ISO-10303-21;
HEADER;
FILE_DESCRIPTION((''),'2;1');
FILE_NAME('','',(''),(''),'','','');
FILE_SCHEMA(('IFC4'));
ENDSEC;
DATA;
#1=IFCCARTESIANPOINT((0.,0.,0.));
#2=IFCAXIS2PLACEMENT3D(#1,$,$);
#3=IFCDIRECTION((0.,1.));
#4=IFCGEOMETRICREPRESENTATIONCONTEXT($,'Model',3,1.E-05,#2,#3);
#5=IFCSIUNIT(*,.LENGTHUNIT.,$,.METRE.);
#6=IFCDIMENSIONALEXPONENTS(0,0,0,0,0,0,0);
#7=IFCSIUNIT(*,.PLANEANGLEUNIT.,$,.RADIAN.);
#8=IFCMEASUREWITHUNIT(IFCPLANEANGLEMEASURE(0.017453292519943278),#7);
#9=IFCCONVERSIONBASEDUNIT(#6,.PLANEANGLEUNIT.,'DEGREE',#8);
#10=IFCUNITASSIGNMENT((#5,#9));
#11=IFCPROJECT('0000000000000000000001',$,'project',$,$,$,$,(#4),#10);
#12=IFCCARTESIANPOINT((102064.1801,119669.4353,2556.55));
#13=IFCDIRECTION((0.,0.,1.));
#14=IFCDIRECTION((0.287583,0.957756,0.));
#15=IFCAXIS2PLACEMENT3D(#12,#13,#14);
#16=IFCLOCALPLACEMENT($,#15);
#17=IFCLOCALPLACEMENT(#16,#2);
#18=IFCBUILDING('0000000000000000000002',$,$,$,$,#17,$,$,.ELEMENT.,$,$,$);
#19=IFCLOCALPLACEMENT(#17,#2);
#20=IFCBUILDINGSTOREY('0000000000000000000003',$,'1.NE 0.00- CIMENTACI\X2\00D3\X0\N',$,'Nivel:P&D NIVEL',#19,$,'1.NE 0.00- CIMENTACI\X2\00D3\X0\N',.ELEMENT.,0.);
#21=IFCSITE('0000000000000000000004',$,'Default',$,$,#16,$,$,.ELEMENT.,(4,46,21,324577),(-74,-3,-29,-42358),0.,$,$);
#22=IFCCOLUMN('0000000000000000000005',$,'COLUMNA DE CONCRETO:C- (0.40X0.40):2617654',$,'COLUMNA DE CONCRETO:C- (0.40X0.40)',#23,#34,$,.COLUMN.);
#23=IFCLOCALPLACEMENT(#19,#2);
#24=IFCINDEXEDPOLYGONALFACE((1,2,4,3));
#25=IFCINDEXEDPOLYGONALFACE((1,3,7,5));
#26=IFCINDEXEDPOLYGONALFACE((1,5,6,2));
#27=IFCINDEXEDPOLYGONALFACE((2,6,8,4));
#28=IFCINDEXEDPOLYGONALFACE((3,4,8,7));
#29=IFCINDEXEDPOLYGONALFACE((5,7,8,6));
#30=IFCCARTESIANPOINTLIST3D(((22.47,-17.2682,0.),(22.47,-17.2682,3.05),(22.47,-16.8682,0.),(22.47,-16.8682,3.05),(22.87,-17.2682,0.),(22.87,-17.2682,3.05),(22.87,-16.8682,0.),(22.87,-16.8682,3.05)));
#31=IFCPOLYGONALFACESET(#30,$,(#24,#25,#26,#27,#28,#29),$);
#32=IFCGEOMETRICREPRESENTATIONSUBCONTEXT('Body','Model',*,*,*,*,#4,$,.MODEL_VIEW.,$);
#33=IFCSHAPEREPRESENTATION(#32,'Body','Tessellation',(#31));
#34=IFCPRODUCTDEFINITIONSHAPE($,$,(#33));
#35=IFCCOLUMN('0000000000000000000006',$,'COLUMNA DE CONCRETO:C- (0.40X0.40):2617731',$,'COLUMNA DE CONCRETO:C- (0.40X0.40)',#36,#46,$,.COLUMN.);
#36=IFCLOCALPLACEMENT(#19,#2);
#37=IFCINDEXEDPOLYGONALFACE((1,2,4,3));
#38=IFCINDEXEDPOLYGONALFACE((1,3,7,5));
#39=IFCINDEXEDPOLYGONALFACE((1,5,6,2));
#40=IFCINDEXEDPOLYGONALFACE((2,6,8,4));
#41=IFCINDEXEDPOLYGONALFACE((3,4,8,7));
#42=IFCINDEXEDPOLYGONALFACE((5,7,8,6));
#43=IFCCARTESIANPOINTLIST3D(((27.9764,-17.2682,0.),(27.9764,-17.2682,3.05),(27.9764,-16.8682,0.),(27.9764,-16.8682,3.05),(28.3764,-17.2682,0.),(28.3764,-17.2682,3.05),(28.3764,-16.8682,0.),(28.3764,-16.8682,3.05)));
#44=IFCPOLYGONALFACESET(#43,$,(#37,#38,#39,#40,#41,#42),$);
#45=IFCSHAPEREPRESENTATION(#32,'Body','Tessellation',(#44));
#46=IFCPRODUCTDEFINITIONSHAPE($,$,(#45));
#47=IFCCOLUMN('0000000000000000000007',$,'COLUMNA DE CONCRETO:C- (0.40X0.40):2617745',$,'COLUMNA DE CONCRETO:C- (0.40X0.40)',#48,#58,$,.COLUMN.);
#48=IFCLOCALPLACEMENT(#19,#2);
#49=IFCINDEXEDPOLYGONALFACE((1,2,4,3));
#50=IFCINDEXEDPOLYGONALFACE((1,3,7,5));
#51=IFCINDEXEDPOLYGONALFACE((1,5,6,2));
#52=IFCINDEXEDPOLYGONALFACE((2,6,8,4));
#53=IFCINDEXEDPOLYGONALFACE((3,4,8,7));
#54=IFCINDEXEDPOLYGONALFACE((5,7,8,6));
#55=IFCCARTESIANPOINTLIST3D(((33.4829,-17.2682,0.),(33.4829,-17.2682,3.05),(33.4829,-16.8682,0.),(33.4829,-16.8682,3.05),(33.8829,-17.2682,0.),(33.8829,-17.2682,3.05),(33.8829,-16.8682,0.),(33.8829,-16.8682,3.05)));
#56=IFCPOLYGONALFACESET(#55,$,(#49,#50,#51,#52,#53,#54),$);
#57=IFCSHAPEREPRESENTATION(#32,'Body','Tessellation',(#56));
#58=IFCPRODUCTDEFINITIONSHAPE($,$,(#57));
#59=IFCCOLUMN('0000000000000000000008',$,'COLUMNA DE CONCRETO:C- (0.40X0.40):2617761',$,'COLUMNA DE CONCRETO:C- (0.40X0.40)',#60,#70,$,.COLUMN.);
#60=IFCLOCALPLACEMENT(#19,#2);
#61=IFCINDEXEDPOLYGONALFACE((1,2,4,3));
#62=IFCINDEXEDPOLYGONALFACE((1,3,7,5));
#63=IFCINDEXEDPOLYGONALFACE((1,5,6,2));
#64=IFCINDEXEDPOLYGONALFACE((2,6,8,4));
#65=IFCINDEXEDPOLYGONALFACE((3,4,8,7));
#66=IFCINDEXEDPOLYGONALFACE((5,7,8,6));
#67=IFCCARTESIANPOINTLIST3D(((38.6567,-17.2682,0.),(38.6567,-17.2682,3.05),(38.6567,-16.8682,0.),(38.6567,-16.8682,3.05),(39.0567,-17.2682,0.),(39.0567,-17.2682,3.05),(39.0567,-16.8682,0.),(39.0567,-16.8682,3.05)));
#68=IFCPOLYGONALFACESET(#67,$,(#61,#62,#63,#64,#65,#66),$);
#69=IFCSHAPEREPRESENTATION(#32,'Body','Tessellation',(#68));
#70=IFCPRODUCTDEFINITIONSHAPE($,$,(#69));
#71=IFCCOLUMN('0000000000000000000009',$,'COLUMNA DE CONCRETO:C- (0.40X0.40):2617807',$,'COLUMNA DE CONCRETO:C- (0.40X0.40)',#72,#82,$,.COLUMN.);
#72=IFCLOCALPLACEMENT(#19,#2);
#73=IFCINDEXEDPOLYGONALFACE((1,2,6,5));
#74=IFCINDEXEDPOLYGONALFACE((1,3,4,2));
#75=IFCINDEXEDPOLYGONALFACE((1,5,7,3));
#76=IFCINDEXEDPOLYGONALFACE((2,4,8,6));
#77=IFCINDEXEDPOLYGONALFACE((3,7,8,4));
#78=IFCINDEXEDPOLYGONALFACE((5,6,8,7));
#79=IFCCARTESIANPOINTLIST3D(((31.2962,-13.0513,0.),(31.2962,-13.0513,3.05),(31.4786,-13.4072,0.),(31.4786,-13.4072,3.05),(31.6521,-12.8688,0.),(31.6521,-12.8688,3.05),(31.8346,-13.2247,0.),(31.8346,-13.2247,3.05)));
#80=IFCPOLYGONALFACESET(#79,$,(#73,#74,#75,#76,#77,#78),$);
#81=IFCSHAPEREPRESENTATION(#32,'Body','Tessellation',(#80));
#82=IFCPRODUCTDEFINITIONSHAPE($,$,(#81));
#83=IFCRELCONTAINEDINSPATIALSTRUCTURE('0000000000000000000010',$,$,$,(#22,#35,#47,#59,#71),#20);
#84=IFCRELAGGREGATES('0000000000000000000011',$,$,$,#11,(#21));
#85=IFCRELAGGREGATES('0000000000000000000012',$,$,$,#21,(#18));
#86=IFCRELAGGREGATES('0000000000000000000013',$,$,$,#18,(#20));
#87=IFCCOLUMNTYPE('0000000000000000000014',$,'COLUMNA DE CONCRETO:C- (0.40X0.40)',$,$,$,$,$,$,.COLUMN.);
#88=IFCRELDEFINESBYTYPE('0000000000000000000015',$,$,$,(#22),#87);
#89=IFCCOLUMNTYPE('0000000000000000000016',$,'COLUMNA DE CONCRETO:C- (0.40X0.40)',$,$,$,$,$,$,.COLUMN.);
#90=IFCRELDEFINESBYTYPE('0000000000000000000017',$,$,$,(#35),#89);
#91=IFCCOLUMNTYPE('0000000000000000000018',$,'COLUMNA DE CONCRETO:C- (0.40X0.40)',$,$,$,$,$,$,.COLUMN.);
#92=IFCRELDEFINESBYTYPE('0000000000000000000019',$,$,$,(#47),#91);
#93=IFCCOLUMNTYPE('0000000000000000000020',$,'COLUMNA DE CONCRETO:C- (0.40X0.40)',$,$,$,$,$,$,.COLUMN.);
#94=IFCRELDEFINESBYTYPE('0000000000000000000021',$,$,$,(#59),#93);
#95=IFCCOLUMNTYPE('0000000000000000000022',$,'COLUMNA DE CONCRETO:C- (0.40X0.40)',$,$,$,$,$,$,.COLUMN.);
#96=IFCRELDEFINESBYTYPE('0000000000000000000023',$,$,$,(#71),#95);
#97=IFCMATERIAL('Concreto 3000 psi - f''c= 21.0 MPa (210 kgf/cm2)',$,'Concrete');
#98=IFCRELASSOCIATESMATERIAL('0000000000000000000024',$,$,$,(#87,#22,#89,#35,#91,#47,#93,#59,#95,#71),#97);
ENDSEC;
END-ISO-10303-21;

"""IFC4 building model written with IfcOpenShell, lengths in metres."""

from ifc_helpers import new_model, entity, si_unit, converted_unit, direction, frame, origin, place, context, subcontext, project, spatial, indexed_curve, outline, extrude, source, transform, mapped, material, type_object, type_shapes, element, save


model = new_model("IFC4")

# Units and contexts
model_context = context("Model", 3, precision=1e-05, world=origin(), true_north=direction((0.0, 1.0)))
body_context = subcontext(model_context, "Body", "Model", "MODEL_VIEW")
ifc_project = project(units=[si_unit("LENGTHUNIT", "METRE"), converted_unit("PLANEANGLEUNIT", "DEGREE", entity("IfcPlaneAngleMeasure", 0.017453292519943278), si_unit("PLANEANGLEUNIT", "RADIAN"), dimensions=[0, 0, 0, 0, 0, 0, 0])], contexts=[model_context])

# Site, building, storey
site_placement = place(None, frame((102064.1801, 119669.4353, 2556.55), z_axis=(0.0, 0.0, 1.0), x_axis=(0.287583, 0.957756, 0.0)))
site = spatial("IfcSite", under=ifc_project, at=site_placement, Name="Default", CompositionType="ELEMENT", RefLatitude=(4, 46, 21, 324577), RefLongitude=(-74, -3, -29, -42358), RefElevation=0.0)
building_placement = place(site_placement, origin())
building = spatial("IfcBuilding", under=site, at=building_placement, CompositionType="ELEMENT")
storey_placement = place(building_placement, origin())
storey = spatial("IfcBuildingStorey", under=building, at=storey_placement, Name="1.NE 0.00- CIMENTACIÓN", ObjectType="Nivel:P&D NIVEL", LongName="1.NE 0.00- CIMENTACIÓN", CompositionType="ELEMENT", Elevation=0.0)

# Columns
ifc_material = material(Name="Concreto 3000 psi - f'c= 21.0 MPa (210 kgf/cm2)", Category="Concrete")
column_type_1 = type_object("IfcColumnType", Name="COLUMNA DE CONCRETO:C- (0.40X0.40)", PredefinedType="COLUMN", material=ifc_material)
shared_shape_1 = source(origin(), body_context, "Body", "SweptSolid", [
    extrude(outline(indexed_curve([(-0.2, -0.2), (0.2, -0.2), (0.2, 0.2), (-0.2, 0.2), (-0.2, -0.2)], self_intersect=False)), frame((22.67, -17.0682, 0.0), z_axis=(0.0, 0.0, 1.0), x_axis=(-1.0, 0.0, 0.0)), (0.0, 0.0, 1.0), 3.05),
])
type_shapes(column_type_1, [shared_shape_1])
column_1_placement = place(storey_placement, origin())
element("IfcColumn", 1, at=column_1_placement, inside=storey, type_object=column_type_1, material=ifc_material, Name="COLUMNA DE CONCRETO:C- (0.40X0.40):2617654", ObjectType="COLUMNA DE CONCRETO:C- (0.40X0.40)", PredefinedType="COLUMN", context=body_context, shape_type="MappedRepresentation", body=[
    mapped(shared_shape_1, transform((0.0, 0.0, 0.0), scale=1.0)),
])
column_type_2 = type_object("IfcColumnType", Name="COLUMNA DE CONCRETO:C- (0.40X0.40)", PredefinedType="COLUMN", material=ifc_material)
shared_shape_2 = source(origin(), body_context, "Body", "SweptSolid", [
    extrude(outline(indexed_curve([(-0.2, -0.2), (0.2, -0.2), (0.2, 0.2), (-0.2, 0.2), (-0.2, -0.2)], self_intersect=False)), frame((28.1764, -17.0682, 0.0), z_axis=(0.0, 0.0, 1.0), x_axis=(-1.0, 0.0, 0.0)), (0.0, 0.0, 1.0), 3.05),
])
type_shapes(column_type_2, [shared_shape_2])
column_2_placement = place(storey_placement, origin())
element("IfcColumn", 2, at=column_2_placement, inside=storey, type_object=column_type_2, material=ifc_material, Name="COLUMNA DE CONCRETO:C- (0.40X0.40):2617731", ObjectType="COLUMNA DE CONCRETO:C- (0.40X0.40)", PredefinedType="COLUMN", context=body_context, shape_type="MappedRepresentation", body=[
    mapped(shared_shape_2, transform((0.0, 0.0, 0.0), scale=1.0)),
])
column_type_3 = type_object("IfcColumnType", Name="COLUMNA DE CONCRETO:C- (0.40X0.40)", PredefinedType="COLUMN", material=ifc_material)
shared_shape_3 = source(origin(), body_context, "Body", "SweptSolid", [
    extrude(outline(indexed_curve([(-0.2, -0.2), (0.2, -0.2), (0.2, 0.2), (-0.2, 0.2), (-0.2, -0.2)], self_intersect=False)), frame((33.6829, -17.0682, 0.0), z_axis=(0.0, 0.0, 1.0), x_axis=(-1.0, 0.0, 0.0)), (0.0, 0.0, 1.0), 3.05),
])
type_shapes(column_type_3, [shared_shape_3])
column_3_placement = place(storey_placement, origin())
element("IfcColumn", 3, at=column_3_placement, inside=storey, type_object=column_type_3, material=ifc_material, Name="COLUMNA DE CONCRETO:C- (0.40X0.40):2617745", ObjectType="COLUMNA DE CONCRETO:C- (0.40X0.40)", PredefinedType="COLUMN", context=body_context, shape_type="MappedRepresentation", body=[
    mapped(shared_shape_3, transform((0.0, 0.0, 0.0), scale=1.0)),
])
column_type_4 = type_object("IfcColumnType", Name="COLUMNA DE CONCRETO:C- (0.40X0.40)", PredefinedType="COLUMN", material=ifc_material)
shared_shape_4 = source(origin(), body_context, "Body", "SweptSolid", [
    extrude(outline(indexed_curve([(-0.2, -0.2), (0.2, -0.2), (0.2, 0.2), (-0.2, 0.2), (-0.2, -0.2)], self_intersect=False)), frame((38.8567, -17.0682, 0.0), z_axis=(0.0, 0.0, 1.0), x_axis=(-1.0, 0.0, 0.0)), (0.0, 0.0, 1.0), 3.05),
])
type_shapes(column_type_4, [shared_shape_4])
column_4_placement = place(storey_placement, origin())
element("IfcColumn", 4, at=column_4_placement, inside=storey, type_object=column_type_4, material=ifc_material, Name="COLUMNA DE CONCRETO:C- (0.40X0.40):2617761", ObjectType="COLUMNA DE CONCRETO:C- (0.40X0.40)", PredefinedType="COLUMN", context=body_context, shape_type="MappedRepresentation", body=[
    mapped(shared_shape_4, transform((0.0, 0.0, 0.0), scale=1.0)),
])
column_type_5 = type_object("IfcColumnType", Name="COLUMNA DE CONCRETO:C- (0.40X0.40)", PredefinedType="COLUMN", material=ifc_material)
shared_shape_5 = source(origin(), body_context, "Body", "SweptSolid", [
    extrude(outline(indexed_curve([(-0.2, -0.2), (0.2, -0.2), (0.2, 0.2), (-0.2, 0.2), (-0.2, -0.2)], self_intersect=False)), frame((31.5654, -13.138, 0.0), z_axis=(0.0, 0.0, 1.0), x_axis=(-0.889869, -0.456217, 0.0)), (0.0, 0.0, 1.0), 3.05),
])
type_shapes(column_type_5, [shared_shape_5])
column_5_placement = place(storey_placement, origin())
element("IfcColumn", 5, at=column_5_placement, inside=storey, type_object=column_type_5, material=ifc_material, Name="COLUMNA DE CONCRETO:C- (0.40X0.40):2617807", ObjectType="COLUMNA DE CONCRETO:C- (0.40X0.40)", PredefinedType="COLUMN", context=body_context, shape_type="MappedRepresentation", body=[
    mapped(shared_shape_5, transform((0.0, 0.0, 0.0), scale=1.0)),
])

save(model, "model.ifc")
